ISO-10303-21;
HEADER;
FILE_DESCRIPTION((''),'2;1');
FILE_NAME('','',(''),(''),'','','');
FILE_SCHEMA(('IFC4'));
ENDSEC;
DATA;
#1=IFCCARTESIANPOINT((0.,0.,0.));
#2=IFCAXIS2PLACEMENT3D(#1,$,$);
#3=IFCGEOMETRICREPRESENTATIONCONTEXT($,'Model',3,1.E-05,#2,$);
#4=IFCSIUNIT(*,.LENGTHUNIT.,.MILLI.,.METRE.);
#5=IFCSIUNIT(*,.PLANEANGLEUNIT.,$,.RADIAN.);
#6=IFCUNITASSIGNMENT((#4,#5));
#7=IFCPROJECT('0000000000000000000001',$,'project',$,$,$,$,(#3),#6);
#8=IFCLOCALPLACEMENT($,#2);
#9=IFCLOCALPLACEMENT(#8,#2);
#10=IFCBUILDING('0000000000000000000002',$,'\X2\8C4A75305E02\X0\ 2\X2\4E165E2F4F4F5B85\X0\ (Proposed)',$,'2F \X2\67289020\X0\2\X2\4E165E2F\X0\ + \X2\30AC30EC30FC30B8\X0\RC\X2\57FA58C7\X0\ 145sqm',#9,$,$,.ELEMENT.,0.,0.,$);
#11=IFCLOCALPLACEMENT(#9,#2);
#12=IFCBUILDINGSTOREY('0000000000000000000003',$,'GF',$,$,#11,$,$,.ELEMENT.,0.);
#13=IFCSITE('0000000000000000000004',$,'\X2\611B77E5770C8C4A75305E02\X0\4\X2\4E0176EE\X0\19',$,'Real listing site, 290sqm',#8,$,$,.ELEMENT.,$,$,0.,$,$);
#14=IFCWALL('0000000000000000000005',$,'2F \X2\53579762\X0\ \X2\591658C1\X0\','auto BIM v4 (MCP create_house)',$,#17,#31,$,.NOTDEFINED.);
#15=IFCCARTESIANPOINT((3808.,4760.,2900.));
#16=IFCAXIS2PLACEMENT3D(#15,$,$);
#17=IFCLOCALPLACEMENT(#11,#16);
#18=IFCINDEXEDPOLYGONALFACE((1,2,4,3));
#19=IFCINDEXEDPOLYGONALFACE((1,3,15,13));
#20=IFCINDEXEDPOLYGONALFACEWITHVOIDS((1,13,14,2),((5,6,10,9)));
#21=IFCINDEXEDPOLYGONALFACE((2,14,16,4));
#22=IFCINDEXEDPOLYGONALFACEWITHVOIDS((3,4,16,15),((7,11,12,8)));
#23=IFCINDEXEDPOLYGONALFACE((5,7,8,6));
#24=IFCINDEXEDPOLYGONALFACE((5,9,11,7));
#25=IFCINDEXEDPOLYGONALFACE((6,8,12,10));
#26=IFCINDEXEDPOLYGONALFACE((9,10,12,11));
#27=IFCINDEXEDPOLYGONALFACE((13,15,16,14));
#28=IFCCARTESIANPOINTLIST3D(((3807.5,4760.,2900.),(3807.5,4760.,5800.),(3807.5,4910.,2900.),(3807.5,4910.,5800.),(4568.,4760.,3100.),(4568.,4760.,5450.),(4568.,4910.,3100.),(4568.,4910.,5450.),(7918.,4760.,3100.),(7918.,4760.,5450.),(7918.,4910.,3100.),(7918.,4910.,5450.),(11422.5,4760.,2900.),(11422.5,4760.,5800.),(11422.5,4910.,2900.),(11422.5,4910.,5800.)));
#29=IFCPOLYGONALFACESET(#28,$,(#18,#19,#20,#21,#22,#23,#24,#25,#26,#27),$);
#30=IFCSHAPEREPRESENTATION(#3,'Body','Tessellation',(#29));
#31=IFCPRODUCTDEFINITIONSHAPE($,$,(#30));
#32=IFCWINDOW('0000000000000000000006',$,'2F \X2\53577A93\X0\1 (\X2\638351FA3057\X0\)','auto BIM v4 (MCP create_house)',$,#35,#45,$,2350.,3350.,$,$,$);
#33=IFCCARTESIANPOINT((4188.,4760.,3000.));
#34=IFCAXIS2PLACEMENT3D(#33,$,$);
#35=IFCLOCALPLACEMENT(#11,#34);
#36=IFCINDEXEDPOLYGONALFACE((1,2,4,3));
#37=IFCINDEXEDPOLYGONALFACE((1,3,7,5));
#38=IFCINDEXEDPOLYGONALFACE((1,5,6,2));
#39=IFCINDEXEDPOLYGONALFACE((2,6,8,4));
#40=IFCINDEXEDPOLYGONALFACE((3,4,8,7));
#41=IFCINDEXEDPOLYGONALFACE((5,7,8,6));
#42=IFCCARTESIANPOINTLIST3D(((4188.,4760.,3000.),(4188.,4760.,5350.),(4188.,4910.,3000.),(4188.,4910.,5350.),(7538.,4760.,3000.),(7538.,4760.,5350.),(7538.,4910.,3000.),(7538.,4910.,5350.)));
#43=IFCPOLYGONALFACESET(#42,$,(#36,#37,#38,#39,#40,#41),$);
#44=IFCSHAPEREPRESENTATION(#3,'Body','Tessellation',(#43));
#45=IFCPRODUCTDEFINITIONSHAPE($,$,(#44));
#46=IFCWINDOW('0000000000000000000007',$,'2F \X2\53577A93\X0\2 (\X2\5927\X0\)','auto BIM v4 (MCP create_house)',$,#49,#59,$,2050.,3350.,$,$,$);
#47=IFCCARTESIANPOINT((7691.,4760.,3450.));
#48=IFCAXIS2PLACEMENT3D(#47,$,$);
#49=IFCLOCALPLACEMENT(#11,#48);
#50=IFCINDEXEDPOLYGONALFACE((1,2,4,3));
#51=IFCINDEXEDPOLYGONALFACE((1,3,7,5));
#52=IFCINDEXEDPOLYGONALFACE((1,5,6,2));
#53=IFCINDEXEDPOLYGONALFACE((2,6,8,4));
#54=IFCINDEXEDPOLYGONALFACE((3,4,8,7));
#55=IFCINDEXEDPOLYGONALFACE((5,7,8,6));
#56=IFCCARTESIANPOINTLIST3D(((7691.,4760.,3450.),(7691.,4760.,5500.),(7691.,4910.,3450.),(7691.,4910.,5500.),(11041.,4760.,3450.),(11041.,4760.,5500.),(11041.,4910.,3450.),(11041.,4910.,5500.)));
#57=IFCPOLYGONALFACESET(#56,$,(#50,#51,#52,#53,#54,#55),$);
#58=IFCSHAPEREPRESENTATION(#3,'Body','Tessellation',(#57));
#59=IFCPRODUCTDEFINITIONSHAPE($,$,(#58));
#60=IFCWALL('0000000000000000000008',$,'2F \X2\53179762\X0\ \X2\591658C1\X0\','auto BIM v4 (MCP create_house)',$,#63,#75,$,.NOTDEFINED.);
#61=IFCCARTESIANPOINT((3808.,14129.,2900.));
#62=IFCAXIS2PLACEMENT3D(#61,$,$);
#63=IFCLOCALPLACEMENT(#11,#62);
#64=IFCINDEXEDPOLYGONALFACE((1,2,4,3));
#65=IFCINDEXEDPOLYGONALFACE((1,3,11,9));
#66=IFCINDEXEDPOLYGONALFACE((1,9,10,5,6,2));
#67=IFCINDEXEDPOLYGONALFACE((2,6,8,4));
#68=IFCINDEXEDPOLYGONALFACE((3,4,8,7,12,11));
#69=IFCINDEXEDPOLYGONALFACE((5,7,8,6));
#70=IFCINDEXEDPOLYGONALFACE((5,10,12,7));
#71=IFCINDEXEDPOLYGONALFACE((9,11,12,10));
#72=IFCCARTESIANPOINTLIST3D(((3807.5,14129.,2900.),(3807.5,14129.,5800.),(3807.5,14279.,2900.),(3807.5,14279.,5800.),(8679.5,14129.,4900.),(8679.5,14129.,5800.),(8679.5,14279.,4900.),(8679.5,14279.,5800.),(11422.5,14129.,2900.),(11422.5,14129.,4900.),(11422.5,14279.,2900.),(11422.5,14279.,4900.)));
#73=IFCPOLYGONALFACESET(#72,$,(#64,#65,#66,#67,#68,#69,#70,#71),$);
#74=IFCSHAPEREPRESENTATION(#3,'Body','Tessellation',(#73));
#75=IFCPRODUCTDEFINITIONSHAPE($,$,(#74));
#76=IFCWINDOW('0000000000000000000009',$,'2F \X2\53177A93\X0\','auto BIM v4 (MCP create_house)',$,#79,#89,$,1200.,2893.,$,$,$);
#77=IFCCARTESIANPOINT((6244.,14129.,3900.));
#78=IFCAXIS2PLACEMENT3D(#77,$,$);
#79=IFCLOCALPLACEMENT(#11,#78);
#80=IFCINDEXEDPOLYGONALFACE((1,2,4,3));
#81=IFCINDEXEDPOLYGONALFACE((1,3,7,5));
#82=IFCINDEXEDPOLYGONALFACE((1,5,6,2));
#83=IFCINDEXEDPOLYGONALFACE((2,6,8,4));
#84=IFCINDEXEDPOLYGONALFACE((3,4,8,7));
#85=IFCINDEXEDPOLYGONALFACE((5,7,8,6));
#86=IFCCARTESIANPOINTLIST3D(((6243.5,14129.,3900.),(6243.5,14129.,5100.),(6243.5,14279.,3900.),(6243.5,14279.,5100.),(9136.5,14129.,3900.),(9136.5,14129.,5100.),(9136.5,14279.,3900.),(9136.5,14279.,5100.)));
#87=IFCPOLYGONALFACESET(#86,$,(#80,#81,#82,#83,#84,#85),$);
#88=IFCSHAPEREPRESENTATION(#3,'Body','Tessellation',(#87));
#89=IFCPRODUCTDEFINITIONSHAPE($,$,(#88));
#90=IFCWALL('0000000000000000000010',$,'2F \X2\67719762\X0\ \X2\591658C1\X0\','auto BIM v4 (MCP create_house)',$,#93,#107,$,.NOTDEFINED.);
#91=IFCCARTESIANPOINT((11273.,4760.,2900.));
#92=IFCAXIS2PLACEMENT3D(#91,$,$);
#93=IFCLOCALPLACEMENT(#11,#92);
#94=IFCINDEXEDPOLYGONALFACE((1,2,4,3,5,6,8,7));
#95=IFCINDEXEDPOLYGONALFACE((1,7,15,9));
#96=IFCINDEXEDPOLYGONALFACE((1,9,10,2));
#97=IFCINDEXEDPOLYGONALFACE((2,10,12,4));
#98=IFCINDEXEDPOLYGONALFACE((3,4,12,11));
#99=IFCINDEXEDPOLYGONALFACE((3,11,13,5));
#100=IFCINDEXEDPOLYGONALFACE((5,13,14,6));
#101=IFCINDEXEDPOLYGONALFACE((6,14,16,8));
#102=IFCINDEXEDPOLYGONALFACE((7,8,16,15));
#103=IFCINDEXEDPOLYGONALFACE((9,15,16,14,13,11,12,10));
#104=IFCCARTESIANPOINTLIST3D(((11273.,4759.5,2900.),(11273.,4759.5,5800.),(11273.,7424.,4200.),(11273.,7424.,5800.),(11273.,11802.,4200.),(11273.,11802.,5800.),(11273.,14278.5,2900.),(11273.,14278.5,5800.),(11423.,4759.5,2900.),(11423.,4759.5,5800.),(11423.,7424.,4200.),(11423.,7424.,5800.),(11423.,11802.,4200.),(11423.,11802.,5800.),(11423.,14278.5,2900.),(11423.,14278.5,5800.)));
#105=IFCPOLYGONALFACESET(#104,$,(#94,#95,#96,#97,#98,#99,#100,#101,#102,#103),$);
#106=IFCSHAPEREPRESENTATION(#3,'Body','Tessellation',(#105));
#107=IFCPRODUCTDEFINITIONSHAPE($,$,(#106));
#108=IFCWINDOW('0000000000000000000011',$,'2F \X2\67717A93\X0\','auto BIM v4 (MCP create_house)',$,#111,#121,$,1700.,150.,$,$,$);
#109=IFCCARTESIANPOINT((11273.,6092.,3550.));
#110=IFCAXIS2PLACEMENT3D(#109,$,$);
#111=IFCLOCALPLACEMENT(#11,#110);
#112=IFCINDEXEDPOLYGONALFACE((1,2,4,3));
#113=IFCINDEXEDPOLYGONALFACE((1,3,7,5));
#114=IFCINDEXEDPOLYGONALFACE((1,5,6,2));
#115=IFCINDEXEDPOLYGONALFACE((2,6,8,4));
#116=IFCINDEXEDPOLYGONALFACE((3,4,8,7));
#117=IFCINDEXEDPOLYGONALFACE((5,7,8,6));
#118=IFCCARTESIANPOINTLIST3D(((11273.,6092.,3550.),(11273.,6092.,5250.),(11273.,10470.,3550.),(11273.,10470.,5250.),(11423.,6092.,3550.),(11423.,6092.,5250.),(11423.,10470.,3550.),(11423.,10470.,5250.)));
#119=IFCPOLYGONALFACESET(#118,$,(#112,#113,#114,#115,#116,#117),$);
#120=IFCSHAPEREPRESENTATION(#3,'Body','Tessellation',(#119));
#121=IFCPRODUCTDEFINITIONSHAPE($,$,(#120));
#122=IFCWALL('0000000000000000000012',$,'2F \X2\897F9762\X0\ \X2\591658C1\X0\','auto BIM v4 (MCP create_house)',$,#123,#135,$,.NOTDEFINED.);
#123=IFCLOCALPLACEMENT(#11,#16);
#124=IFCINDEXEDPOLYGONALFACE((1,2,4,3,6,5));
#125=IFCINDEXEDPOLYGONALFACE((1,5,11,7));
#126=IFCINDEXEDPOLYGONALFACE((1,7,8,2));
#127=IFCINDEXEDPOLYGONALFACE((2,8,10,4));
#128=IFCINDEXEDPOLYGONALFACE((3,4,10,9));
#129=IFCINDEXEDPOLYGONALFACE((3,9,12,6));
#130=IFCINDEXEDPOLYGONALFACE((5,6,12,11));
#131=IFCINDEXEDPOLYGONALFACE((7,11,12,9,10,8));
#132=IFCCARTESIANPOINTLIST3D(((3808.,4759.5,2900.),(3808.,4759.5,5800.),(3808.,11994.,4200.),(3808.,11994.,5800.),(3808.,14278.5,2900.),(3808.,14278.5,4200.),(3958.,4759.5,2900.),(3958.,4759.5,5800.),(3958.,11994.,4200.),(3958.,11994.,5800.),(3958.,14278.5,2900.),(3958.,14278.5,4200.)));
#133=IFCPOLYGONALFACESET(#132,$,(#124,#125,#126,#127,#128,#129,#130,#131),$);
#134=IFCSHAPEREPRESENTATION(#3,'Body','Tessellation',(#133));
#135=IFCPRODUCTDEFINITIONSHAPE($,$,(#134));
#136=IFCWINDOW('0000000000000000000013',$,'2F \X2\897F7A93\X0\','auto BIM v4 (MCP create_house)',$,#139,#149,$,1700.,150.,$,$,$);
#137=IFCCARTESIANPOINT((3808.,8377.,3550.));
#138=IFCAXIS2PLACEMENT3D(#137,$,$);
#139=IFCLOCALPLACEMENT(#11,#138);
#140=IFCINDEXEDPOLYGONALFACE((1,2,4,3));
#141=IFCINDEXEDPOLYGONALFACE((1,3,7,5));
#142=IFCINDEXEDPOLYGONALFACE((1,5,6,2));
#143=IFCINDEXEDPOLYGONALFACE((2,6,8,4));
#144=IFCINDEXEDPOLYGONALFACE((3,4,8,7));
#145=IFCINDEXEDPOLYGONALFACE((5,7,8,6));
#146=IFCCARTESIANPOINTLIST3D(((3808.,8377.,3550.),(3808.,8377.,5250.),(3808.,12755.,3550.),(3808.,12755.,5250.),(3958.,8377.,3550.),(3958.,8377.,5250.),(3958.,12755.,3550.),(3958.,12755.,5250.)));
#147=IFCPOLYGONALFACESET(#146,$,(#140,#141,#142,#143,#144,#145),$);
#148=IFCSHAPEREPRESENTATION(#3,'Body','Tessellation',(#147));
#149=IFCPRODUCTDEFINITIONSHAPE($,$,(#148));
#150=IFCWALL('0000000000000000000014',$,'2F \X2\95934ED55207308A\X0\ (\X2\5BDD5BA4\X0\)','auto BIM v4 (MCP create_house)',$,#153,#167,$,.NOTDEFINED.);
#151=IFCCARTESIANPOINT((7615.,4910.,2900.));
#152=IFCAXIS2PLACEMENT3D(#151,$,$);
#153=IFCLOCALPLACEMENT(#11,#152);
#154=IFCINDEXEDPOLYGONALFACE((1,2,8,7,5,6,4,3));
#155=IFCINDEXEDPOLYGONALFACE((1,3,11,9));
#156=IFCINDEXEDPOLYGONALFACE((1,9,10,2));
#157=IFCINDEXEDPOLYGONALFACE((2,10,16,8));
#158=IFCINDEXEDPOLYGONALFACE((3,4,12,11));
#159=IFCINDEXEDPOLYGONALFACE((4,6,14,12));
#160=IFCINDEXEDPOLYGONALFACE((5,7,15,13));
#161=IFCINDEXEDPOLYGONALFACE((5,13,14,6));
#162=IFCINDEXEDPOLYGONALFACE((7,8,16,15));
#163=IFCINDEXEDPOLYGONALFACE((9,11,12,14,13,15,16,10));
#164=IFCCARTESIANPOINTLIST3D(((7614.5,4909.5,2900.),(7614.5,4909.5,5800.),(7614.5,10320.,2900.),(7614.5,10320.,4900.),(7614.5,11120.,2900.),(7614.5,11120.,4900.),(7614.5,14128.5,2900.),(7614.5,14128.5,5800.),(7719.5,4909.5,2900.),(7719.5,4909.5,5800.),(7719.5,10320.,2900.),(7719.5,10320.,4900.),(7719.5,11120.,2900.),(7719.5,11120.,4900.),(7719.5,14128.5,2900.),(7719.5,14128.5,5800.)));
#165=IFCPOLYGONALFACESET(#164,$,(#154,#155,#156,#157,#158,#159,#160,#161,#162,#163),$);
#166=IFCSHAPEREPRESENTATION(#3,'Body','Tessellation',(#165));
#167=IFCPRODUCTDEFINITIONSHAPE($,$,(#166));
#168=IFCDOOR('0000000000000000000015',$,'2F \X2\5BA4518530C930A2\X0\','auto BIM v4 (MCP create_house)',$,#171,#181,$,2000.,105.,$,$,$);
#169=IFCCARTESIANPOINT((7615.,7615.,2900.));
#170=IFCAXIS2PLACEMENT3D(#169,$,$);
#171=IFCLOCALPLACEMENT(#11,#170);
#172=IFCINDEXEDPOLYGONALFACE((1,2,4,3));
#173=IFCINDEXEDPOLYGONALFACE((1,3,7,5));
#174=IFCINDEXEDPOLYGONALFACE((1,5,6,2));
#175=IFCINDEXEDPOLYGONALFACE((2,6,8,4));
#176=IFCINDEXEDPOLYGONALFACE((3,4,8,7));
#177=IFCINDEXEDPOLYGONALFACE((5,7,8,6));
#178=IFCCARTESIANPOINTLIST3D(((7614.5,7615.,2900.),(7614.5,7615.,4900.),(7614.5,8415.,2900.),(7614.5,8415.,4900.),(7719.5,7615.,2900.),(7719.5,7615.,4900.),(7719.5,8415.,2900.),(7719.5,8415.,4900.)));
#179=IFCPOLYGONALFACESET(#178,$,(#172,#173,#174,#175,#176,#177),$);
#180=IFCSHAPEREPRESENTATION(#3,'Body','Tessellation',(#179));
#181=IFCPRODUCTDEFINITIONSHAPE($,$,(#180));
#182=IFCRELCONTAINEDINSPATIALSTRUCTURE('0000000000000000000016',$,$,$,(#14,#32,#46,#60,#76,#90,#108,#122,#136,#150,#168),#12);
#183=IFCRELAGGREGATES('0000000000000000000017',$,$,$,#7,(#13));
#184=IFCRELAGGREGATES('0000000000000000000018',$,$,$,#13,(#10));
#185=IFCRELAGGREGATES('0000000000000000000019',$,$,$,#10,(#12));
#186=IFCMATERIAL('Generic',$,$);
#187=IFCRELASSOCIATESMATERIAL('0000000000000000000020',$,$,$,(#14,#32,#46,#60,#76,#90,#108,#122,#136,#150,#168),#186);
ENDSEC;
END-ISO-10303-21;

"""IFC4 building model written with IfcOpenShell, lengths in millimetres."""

from ifc_helpers import new_model, si_unit, frame, frame_2d, origin, place, context, project, spatial, rectangle, extrude, material, element, fill, save


model = new_model("IFC4")

# Units and contexts
model_context = context("Model", 3, precision=1e-05, world=origin())
ifc_project = project(units=[si_unit("LENGTHUNIT", "METRE", prefix="MILLI"), si_unit("PLANEANGLEUNIT", "RADIAN")], contexts=[model_context])

# Site, building, storey
site_placement = place(None, origin())
site = spatial("IfcSite", under=ifc_project, at=site_placement, Name="愛知県豊田市4丁目19", ObjectType="Real listing site, 290sqm", CompositionType="ELEMENT", RefElevation=0.0)
building_placement = place(site_placement, origin())
building = spatial("IfcBuilding", under=site, at=building_placement, Name="豊田市 2世帯住宅 (Proposed)", ObjectType="2F 木造2世帯 + ガレージRC基壇 145sqm", CompositionType="ELEMENT", ElevationOfRefHeight=0.0, ElevationOfTerrain=0.0)
storey_placement = place(building_placement, origin())
storey = spatial("IfcBuildingStorey", under=building, at=storey_placement, Name="GF", CompositionType="ELEMENT", Elevation=0.0)

# Shared definitions
ifc_material = material(Name="Generic")

# Wall, openings, windows
wall_1_placement = place(storey_placement, frame((3808.0, 4760.0, 2900.0)))
wall_1 = element("IfcWall", 1, at=wall_1_placement, inside=storey, material=ifc_material, Name="2F 南面 外壁", Description="auto BIM v4 (MCP create_house)", PredefinedType="NOTDEFINED", context=model_context, shape_type="SweptSolid", body=[
    extrude(rectangle(XDim=7615.0, YDim=150.0, at=frame_2d((3807.0, 75.0))), frame((3808.0, 4760.0, 2900.0)), (0.0, 0.0, 1.0), 2900.0),
])
opening_1_placement = place(storey_placement, frame((4188.0, 4760.0, 3000.0)))
opening_1 = element("IfcOpeningElement", 2, at=opening_1_placement, cuts=wall_1, PredefinedType="NOTDEFINED", context=model_context, shape_type="SweptSolid", body=[
    extrude(rectangle(XDim=3350.0, YDim=150.0, at=frame_2d((1675.0, 75.0))), frame((4188.0, 4760.0, 3000.0)), (0.0, 0.0, 1.0), 2350.0),
])
opening_2_placement = place(storey_placement, frame((7691.0, 4760.0, 3450.0)))
opening_2 = element("IfcOpeningElement", 3, at=opening_2_placement, cuts=wall_1, PredefinedType="NOTDEFINED", context=model_context, shape_type="SweptSolid", body=[
    extrude(rectangle(XDim=3350.0, YDim=150.0, at=frame_2d((1675.0, 75.0))), frame((7691.0, 4760.0, 3450.0)), (0.0, 0.0, 1.0), 2050.0),
])
window_1_placement = place(storey_placement, frame((4188.0, 4760.0, 3000.0)))
window_1 = element("IfcWindow", 4, at=window_1_placement, inside=storey, material=ifc_material, Name="2F 南窓1 (掃出し)", Description="auto BIM v4 (MCP create_house)", OverallHeight=2350.0, OverallWidth=3350.0, context=model_context, shape_type="SweptSolid", body=[
    extrude(rectangle(XDim=3350.0, YDim=150.0, at=frame_2d((1675.0, 75.0))), frame((4188.0, 4760.0, 3000.0)), (0.0, 0.0, 1.0), 2350.0),
])
fill(opening_1, window_1)
window_2_placement = place(storey_placement, frame((7691.0, 4760.0, 3450.0)))
window_2 = element("IfcWindow", 5, at=window_2_placement, inside=storey, material=ifc_material, Name="2F 南窓2 (大)", Description="auto BIM v4 (MCP create_house)", OverallHeight=2050.0, OverallWidth=3350.0, context=model_context, shape_type="SweptSolid", body=[
    extrude(rectangle(XDim=3350.0, YDim=150.0, at=frame_2d((1675.0, 75.0))), frame((7691.0, 4760.0, 3450.0)), (0.0, 0.0, 1.0), 2050.0),
])
fill(opening_2, window_2)

# Walls, openings, windows
wall_2_placement = place(storey_placement, frame((3808.0, 14129.0, 2900.0)))
wall_2 = element("IfcWall", 6, at=wall_2_placement, inside=storey, material=ifc_material, Name="2F 北面 外壁", Description="auto BIM v4 (MCP create_house)", PredefinedType="NOTDEFINED", context=model_context, shape_type="SweptSolid", body=[
    extrude(rectangle(XDim=7615.0, YDim=150.0, at=frame_2d((3807.0, 75.0))), frame((3808.0, 14129.0, 2900.0)), (0.0, 0.0, 1.0), 2900.0),
])
opening_3_placement = place(storey_placement, frame((6244.0, 14129.0, 3900.0)))
opening_3 = element("IfcOpeningElement", 7, at=opening_3_placement, cuts=wall_2, PredefinedType="NOTDEFINED", context=model_context, shape_type="SweptSolid", body=[
    extrude(rectangle(XDim=2893.0, YDim=150.0, at=frame_2d((1446.0, 75.0))), frame((6244.0, 14129.0, 3900.0)), (0.0, 0.0, 1.0), 1200.0),
])
window_3_placement = place(storey_placement, frame((6244.0, 14129.0, 3900.0)))
window_3 = element("IfcWindow", 8, at=window_3_placement, inside=storey, material=ifc_material, Name="2F 北窓", Description="auto BIM v4 (MCP create_house)", OverallHeight=1200.0, OverallWidth=2893.0, context=model_context, shape_type="SweptSolid", body=[
    extrude(rectangle(XDim=2893.0, YDim=150.0, at=frame_2d((1446.0, 75.0))), frame((6244.0, 14129.0, 3900.0)), (0.0, 0.0, 1.0), 1200.0),
])
fill(opening_3, window_3)
wall_3_placement = place(storey_placement, frame((11273.0, 4760.0, 2900.0)))
wall_3 = element("IfcWall", 9, at=wall_3_placement, inside=storey, material=ifc_material, Name="2F 東面 外壁", Description="auto BIM v4 (MCP create_house)", PredefinedType="NOTDEFINED", context=model_context, shape_type="SweptSolid", body=[
    extrude(rectangle(XDim=150.0, YDim=9519.0, at=frame_2d((75.0, 4759.0))), frame((11273.0, 4760.0, 2900.0)), (0.0, 0.0, 1.0), 2900.0),
])
opening_4_placement = place(storey_placement, frame((11273.0, 6092.0, 3550.0)))
opening_4 = element("IfcOpeningElement", 10, at=opening_4_placement, cuts=wall_3, PredefinedType="NOTDEFINED", context=model_context, shape_type="SweptSolid", body=[
    extrude(rectangle(XDim=150.0, YDim=4378.0, at=frame_2d((75.0, 2189.0))), frame((11273.0, 6092.0, 3550.0)), (0.0, 0.0, 1.0), 1700.0),
])
window_4_placement = place(storey_placement, frame((11273.0, 6092.0, 3550.0)))
window_4 = element("IfcWindow", 11, at=window_4_placement, inside=storey, material=ifc_material, Name="2F 東窓", Description="auto BIM v4 (MCP create_house)", OverallHeight=1700.0, OverallWidth=150.0, context=model_context, shape_type="SweptSolid", body=[
    extrude(rectangle(XDim=150.0, YDim=4378.0, at=frame_2d((75.0, 2189.0))), frame((11273.0, 6092.0, 3550.0)), (0.0, 0.0, 1.0), 1700.0),
])
fill(opening_4, window_4)
wall_4_placement = place(storey_placement, frame((3808.0, 4760.0, 2900.0)))
wall_4 = element("IfcWall", 12, at=wall_4_placement, inside=storey, material=ifc_material, Name="2F 西面 外壁", Description="auto BIM v4 (MCP create_house)", PredefinedType="NOTDEFINED", context=model_context, shape_type="SweptSolid", body=[
    extrude(rectangle(XDim=150.0, YDim=9519.0, at=frame_2d((75.0, 4759.0))), frame((3808.0, 4760.0, 2900.0)), (0.0, 0.0, 1.0), 2900.0),
])
opening_5_placement = place(storey_placement, frame((3808.0, 8377.0, 3550.0)))
opening_5 = element("IfcOpeningElement", 13, at=opening_5_placement, cuts=wall_4, PredefinedType="NOTDEFINED", context=model_context, shape_type="SweptSolid", body=[
    extrude(rectangle(XDim=150.0, YDim=4378.0, at=frame_2d((75.0, 2189.0))), frame((3808.0, 8377.0, 3550.0)), (0.0, 0.0, 1.0), 1700.0),
])
window_5_placement = place(storey_placement, frame((3808.0, 8377.0, 3550.0)))
window_5 = element("IfcWindow", 14, at=window_5_placement, inside=storey, material=ifc_material, Name="2F 西窓", Description="auto BIM v4 (MCP create_house)", OverallHeight=1700.0, OverallWidth=150.0, context=model_context, shape_type="SweptSolid", body=[
    extrude(rectangle(XDim=150.0, YDim=4378.0, at=frame_2d((75.0, 2189.0))), frame((3808.0, 8377.0, 3550.0)), (0.0, 0.0, 1.0), 1700.0),
])
fill(opening_5, window_5)

# Wall, opening, door
wall_5_placement = place(storey_placement, frame((7615.0, 4910.0, 2900.0)))
wall_5 = element("IfcWall", 15, at=wall_5_placement, inside=storey, material=ifc_material, Name="2F 間仕切り (寝室)", Description="auto BIM v4 (MCP create_house)", PredefinedType="NOTDEFINED", context=model_context, shape_type="SweptSolid", body=[
    extrude(rectangle(XDim=105.0, YDim=9219.0, at=frame_2d((52.0, 4609.0))), frame((7615.0, 4910.0, 2900.0)), (0.0, 0.0, 1.0), 2900.0),
])
opening_6_placement = place(storey_placement, frame((7615.0, 7615.0, 2900.0)))
opening_6 = element("IfcOpeningElement", 16, at=opening_6_placement, cuts=wall_5, PredefinedType="NOTDEFINED", context=model_context, shape_type="SweptSolid", body=[
    extrude(rectangle(XDim=105.0, YDim=800.0, at=frame_2d((52.0, 400.0))), frame((7615.0, 7615.0, 2900.0)), (0.0, 0.0, 1.0), 2000.0),
])
door_1_placement = place(storey_placement, frame((7615.0, 7615.0, 2900.0)))
door_1 = element("IfcDoor", 17, at=door_1_placement, inside=storey, material=ifc_material, Name="2F 室内ドア", Description="auto BIM v4 (MCP create_house)", OverallHeight=2000.0, OverallWidth=105.0, context=model_context, shape_type="SweptSolid", body=[
    extrude(rectangle(XDim=105.0, YDim=800.0, at=frame_2d((52.0, 400.0))), frame((7615.0, 7615.0, 2900.0)), (0.0, 0.0, 1.0), 2000.0),
])
fill(opening_6, door_1)

save(model, "model.ifc")
